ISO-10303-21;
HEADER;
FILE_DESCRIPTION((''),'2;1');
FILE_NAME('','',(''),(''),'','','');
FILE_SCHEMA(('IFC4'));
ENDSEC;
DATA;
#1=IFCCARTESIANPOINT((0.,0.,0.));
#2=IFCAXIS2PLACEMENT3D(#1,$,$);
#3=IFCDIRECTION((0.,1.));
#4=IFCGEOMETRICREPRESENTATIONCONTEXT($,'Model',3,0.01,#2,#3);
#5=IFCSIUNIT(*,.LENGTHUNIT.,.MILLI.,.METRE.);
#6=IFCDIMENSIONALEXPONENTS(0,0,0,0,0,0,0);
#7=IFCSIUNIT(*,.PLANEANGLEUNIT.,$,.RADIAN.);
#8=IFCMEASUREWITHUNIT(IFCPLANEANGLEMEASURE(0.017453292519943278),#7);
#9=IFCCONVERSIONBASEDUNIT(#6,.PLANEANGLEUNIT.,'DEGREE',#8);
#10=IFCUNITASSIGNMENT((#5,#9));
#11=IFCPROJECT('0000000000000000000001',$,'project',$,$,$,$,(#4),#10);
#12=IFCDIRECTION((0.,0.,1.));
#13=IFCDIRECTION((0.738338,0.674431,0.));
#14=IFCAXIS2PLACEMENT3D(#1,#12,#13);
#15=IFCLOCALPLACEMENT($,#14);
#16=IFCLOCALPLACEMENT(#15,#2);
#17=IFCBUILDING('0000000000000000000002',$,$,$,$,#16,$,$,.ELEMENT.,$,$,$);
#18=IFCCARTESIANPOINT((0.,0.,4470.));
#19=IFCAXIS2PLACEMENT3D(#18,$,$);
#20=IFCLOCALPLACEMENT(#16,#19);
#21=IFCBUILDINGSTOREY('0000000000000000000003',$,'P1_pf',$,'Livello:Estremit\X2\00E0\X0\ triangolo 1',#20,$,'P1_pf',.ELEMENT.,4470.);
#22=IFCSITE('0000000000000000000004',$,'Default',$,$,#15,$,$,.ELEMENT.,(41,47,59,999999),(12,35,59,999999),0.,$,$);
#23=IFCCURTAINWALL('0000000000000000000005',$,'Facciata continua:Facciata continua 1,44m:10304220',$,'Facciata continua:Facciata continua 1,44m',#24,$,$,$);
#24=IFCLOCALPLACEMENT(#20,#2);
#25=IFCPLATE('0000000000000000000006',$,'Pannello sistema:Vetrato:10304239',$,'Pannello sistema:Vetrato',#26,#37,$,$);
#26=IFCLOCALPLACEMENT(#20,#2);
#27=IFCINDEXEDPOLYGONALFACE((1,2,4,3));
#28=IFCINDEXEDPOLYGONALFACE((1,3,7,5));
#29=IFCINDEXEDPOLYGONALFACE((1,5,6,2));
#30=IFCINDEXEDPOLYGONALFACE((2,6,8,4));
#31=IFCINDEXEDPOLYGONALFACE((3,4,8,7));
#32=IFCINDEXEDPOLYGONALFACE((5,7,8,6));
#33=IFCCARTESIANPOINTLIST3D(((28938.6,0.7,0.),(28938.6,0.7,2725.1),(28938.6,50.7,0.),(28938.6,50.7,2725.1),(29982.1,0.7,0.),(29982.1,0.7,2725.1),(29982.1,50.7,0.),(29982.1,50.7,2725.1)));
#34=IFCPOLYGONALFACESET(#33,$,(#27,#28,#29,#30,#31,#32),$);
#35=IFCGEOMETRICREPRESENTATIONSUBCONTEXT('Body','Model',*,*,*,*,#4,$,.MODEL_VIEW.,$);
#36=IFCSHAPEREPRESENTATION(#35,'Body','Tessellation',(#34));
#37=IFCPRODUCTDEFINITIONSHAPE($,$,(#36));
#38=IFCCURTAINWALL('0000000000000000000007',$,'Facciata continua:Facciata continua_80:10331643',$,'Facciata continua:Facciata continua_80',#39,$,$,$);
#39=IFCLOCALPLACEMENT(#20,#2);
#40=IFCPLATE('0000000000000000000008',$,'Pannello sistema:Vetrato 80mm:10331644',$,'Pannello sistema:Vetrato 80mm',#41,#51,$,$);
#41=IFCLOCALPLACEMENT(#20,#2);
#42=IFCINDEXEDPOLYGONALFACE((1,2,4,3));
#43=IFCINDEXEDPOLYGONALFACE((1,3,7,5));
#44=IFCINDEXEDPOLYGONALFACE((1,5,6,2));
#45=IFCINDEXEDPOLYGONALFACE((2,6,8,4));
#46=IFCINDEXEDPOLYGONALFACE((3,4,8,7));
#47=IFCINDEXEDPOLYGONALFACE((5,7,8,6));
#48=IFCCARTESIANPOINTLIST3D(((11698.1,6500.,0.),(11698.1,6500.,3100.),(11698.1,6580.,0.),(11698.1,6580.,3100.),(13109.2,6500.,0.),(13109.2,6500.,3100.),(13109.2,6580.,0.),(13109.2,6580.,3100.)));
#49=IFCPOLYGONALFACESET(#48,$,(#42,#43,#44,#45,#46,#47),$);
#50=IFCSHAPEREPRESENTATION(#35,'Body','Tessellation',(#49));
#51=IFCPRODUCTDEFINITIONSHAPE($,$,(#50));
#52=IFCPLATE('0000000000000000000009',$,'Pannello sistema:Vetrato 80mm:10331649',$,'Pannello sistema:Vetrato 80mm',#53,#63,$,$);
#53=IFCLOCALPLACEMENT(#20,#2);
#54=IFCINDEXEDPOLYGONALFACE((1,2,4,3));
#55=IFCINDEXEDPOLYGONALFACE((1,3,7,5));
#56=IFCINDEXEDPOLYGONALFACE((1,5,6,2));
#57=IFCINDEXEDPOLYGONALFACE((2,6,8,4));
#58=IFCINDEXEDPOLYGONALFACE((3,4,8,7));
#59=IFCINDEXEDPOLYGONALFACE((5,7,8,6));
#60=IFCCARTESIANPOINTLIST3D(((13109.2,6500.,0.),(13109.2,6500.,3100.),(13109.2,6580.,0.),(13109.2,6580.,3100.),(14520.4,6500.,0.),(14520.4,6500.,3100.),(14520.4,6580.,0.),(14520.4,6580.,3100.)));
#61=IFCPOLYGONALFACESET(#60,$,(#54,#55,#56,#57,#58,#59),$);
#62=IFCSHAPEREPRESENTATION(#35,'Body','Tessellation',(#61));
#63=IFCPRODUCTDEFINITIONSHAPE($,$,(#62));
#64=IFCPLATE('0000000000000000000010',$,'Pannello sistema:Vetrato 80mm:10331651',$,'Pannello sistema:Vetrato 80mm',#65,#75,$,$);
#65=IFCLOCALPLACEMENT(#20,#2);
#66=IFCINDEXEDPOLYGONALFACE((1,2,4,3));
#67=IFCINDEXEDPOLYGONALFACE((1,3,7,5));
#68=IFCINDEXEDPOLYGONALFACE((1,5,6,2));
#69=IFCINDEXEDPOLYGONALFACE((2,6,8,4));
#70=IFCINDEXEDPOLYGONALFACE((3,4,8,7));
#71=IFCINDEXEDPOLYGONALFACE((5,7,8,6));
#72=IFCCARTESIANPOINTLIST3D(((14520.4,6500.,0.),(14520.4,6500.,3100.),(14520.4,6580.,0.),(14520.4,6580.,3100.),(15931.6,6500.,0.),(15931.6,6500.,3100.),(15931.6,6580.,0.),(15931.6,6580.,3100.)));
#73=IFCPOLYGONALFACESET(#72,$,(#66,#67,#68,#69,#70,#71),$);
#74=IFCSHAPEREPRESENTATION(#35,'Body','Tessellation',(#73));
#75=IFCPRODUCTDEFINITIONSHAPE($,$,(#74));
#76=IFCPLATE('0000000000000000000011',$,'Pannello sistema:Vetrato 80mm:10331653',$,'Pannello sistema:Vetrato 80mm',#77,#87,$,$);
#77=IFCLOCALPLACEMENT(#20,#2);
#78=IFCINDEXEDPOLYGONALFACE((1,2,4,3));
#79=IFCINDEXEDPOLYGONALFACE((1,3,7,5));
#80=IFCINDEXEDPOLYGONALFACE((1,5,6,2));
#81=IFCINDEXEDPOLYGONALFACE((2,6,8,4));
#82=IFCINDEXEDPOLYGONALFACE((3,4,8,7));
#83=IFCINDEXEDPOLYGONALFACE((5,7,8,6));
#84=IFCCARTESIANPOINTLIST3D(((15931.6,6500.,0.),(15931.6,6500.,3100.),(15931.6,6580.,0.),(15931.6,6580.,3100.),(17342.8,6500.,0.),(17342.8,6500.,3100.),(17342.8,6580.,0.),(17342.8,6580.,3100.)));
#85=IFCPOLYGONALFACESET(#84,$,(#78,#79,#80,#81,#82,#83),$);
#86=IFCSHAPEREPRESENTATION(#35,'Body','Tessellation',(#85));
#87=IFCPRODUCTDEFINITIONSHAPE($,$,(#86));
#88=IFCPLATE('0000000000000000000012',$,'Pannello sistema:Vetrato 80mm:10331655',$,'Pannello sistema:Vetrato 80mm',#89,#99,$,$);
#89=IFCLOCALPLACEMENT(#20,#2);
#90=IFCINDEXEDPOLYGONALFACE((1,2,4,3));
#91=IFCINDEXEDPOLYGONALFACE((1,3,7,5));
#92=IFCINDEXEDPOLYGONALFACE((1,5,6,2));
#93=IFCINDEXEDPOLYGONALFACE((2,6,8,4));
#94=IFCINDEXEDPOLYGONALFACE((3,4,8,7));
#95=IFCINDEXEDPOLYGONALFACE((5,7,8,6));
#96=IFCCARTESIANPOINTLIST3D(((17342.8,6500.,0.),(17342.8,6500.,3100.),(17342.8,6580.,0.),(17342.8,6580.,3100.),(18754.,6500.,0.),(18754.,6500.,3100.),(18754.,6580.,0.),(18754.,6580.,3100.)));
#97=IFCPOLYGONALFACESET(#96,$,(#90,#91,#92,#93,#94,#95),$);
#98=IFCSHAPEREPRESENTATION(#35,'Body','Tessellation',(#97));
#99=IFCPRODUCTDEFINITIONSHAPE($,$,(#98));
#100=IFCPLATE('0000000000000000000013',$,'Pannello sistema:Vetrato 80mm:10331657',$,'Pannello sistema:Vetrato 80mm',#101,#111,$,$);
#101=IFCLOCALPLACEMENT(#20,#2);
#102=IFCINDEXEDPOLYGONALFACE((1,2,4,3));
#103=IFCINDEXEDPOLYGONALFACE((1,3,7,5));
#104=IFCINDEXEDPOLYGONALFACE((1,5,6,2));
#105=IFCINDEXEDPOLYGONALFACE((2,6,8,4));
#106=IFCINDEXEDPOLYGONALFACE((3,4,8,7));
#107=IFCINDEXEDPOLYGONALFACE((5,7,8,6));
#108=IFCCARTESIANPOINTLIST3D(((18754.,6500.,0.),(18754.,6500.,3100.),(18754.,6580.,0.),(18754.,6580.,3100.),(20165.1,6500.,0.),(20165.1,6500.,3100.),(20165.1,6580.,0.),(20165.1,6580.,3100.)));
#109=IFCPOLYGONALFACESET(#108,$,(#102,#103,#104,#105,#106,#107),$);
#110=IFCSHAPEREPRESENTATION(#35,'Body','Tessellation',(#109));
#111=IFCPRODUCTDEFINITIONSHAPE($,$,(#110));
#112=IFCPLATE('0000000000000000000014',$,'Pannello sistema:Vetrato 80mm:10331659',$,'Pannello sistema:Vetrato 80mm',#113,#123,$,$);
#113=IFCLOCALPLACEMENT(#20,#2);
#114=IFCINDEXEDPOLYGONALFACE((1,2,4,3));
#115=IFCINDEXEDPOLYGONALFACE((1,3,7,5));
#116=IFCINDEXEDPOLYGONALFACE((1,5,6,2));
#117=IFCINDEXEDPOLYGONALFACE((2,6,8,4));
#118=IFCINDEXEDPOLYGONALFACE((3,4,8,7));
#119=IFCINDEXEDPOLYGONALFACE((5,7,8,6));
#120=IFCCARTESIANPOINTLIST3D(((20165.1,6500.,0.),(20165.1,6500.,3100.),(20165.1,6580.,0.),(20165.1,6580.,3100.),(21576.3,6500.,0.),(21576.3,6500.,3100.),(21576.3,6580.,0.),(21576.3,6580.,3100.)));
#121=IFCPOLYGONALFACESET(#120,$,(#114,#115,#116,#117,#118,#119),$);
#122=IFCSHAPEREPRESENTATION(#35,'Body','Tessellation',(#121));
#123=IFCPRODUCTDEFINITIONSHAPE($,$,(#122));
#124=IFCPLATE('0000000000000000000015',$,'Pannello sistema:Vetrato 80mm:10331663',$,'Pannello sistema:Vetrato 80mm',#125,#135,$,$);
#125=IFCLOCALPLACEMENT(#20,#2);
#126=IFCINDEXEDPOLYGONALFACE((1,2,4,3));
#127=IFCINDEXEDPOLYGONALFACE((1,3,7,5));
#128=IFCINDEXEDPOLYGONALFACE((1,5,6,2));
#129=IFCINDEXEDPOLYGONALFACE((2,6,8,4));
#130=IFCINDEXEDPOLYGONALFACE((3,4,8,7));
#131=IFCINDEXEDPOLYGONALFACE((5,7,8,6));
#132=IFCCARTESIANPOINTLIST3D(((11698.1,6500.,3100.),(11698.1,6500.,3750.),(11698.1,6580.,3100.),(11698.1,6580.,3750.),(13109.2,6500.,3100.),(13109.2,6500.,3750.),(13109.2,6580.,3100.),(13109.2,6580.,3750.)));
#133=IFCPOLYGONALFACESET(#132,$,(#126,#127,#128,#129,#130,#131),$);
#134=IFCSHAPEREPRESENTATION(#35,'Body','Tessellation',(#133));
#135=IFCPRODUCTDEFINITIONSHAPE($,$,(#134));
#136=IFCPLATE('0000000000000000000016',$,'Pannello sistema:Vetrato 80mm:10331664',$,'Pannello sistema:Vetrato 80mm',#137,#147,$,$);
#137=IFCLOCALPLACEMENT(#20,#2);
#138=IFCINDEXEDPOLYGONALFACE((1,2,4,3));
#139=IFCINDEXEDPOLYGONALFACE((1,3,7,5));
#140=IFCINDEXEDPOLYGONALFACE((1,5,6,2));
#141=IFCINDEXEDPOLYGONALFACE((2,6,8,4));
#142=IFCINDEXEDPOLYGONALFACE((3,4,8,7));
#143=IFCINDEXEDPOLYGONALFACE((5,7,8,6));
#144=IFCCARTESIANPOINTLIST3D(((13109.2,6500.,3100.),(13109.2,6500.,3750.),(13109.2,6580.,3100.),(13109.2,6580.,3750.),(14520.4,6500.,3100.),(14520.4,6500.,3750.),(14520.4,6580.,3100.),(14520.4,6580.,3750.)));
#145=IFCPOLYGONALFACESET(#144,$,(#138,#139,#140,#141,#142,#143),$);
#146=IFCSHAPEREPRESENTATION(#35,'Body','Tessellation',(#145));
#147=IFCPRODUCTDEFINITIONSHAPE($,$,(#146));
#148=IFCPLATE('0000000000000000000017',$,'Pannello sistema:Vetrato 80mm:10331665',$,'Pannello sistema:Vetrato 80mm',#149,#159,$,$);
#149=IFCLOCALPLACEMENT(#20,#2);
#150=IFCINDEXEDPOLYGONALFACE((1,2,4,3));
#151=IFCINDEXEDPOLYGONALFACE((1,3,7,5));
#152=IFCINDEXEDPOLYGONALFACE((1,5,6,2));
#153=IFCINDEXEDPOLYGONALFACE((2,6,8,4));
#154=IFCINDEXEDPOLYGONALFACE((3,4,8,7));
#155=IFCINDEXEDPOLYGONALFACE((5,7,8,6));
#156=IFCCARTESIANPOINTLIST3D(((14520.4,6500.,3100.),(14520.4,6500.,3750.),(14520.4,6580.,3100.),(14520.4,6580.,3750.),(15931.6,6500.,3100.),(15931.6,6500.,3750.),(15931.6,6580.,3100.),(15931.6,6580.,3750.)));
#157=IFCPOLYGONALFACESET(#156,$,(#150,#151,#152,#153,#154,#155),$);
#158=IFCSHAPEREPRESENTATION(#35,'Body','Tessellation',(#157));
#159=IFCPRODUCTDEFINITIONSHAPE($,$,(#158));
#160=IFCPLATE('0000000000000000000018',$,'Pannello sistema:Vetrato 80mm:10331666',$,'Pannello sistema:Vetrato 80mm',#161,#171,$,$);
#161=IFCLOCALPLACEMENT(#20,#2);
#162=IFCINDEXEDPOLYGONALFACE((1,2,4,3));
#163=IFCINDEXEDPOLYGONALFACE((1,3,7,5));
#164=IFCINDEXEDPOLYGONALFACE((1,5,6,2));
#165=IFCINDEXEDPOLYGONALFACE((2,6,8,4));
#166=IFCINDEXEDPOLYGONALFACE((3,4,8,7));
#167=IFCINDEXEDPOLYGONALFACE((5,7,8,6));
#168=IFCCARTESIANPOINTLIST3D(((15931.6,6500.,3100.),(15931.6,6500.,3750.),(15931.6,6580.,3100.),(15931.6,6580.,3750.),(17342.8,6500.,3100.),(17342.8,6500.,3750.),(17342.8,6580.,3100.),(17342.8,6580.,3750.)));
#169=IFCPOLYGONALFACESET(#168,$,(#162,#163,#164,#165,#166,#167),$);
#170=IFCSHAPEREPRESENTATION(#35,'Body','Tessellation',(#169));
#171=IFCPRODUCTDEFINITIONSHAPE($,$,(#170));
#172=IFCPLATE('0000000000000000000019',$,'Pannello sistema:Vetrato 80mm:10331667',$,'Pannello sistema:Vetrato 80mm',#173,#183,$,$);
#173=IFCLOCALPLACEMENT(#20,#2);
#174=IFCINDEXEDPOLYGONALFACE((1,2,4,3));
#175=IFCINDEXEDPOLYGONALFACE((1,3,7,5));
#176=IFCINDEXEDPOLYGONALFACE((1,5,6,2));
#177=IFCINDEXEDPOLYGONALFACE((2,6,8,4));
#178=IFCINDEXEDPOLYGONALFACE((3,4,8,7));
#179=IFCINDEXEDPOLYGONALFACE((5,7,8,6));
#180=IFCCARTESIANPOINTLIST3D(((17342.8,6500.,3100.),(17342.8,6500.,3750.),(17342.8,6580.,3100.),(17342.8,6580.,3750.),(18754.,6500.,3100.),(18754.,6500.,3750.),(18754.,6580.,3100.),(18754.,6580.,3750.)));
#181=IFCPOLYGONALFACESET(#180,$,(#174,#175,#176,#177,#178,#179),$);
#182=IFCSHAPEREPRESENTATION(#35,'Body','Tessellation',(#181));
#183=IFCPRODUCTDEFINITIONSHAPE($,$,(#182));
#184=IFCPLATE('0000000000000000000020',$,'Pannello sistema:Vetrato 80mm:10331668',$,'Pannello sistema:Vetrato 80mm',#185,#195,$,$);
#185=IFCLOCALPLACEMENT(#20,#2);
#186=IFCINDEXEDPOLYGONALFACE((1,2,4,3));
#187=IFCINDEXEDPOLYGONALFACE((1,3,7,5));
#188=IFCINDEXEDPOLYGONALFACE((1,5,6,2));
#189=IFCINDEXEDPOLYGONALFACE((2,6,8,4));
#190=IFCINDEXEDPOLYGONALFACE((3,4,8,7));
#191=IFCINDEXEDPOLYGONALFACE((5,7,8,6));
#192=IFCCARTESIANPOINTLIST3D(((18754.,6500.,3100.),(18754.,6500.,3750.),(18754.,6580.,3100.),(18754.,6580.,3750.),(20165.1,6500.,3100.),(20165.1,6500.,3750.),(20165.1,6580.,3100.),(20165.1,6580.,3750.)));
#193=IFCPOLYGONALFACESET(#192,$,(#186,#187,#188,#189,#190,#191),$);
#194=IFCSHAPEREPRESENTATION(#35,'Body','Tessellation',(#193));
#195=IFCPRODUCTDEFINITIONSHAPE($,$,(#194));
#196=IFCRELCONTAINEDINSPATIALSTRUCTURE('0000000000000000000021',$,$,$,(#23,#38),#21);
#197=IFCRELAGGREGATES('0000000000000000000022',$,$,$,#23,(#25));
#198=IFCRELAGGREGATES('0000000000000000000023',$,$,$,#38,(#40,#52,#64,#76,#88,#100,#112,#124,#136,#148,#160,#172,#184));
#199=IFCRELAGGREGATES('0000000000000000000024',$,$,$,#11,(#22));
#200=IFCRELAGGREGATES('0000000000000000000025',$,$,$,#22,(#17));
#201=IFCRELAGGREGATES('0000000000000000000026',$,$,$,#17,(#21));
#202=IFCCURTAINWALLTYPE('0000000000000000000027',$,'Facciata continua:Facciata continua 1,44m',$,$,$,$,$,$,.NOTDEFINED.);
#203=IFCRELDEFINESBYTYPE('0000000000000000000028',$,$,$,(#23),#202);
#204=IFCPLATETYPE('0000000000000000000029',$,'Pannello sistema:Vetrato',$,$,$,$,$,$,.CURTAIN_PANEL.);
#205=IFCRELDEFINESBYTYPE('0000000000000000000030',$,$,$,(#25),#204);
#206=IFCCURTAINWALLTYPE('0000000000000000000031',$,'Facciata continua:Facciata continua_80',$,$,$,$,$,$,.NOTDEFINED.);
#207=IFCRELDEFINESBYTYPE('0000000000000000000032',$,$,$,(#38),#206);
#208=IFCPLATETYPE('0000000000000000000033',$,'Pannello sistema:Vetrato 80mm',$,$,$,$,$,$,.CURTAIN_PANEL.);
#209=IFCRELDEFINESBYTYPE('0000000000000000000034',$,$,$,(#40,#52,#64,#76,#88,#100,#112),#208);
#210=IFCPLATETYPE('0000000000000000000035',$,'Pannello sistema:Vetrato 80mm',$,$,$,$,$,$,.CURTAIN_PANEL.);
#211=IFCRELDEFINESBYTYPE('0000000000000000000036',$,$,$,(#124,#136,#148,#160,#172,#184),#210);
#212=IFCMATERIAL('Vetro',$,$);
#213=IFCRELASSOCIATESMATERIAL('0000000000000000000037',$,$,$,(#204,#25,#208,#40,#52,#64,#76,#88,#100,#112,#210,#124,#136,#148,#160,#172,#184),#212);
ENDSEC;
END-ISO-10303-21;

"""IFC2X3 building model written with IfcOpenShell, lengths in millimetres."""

from ifc_helpers import new_model, entity, si_unit, converted_unit, direction, frame, origin, origin_2d_with_axis, place, context, subcontext, project, spatial, rectangle, extrude, source, transform, mapped, material, type_object, type_shapes, element, aggregate, save


model = new_model("IFC2X3")

# Units and contexts
model_context = context("Model", 3, precision=0.01, world=origin(), true_north=direction((0.0, 1.0)))
body_context = subcontext(model_context, "Body", "Model", "MODEL_VIEW")
ifc_project = project(units=[si_unit("LENGTHUNIT", "METRE", prefix="MILLI"), converted_unit("PLANEANGLEUNIT", "DEGREE", entity("IfcPlaneAngleMeasure", 0.017453292519943278), si_unit("PLANEANGLEUNIT", "RADIAN"), dimensions=[0, 0, 0, 0, 0, 0, 0])], contexts=[model_context])

# Site, building, storey
site_placement = place(None, frame((0.0, 0.0, 0.0), z_axis=(0.0, 0.0, 1.0), x_axis=(0.738338, 0.674431, 0.0)))
site = spatial("IfcSite", under=ifc_project, at=site_placement, Name="Default", CompositionType="ELEMENT", RefLatitude=(41, 47, 59, 999999), RefLongitude=(12, 35, 59, 999999), RefElevation=0.0)
building_placement = place(site_placement, origin())
building = spatial("IfcBuilding", under=site, at=building_placement, CompositionType="ELEMENT")
storey_placement = place(building_placement, frame((0.0, 0.0, 4470.0)))
storey = spatial("IfcBuildingStorey", under=building, at=storey_placement, Name="P1_pf", ObjectType="Livello:Estremità triangolo 1", LongName="P1_pf", CompositionType="ELEMENT", Elevation=4470.0)

# Curtain wall, plate
curtain_wall_type_1 = type_object("IfcCurtainWallType", Name="Facciata continua:Facciata continua 1,44m", PredefinedType="NOTDEFINED")
curtain_wall_1_placement = place(storey_placement, frame((0.0, 0.0, -4470.0)))
curtain_wall_1 = element("IfcCurtainWall", 1, at=curtain_wall_1_placement, inside=storey, type_object=curtain_wall_type_1, Name="Facciata continua:Facciata continua 1,44m:10304220", ObjectType="Facciata continua:Facciata continua 1,44m")
ifc_material_1 = material(Name="Vetro")
plate_type_1 = type_object("IfcPlateType", Name="Pannello sistema:Vetrato", PredefinedType="CURTAIN_PANEL", material=ifc_material_1)
shared_shape_1 = source(origin(), body_context, "Body", "SweptSolid", [
    extrude(rectangle(XDim=50.0, YDim=1043.5, at=origin_2d_with_axis()), frame((0.0, -25.0, 0.0), z_axis=(0.0, 0.0, 1.0), x_axis=(0.0, 1.0, 0.0)), (0.0, 0.0, 1.0), 2725.1),
])
type_shapes(plate_type_1, [shared_shape_1])
plate_1_placement = place(curtain_wall_1_placement, frame((29460.4, 0.7, 4470.0), z_axis=(0.0, 0.0, 1.0), x_axis=(-1.0, 0.0, 0.0)))
plate_1 = element("IfcPlate", 2, at=plate_1_placement, type_object=plate_type_1, material=ifc_material_1, Name="Pannello sistema:Vetrato:10304239", ObjectType="Pannello sistema:Vetrato", context=body_context, shape_type="MappedRepresentation", body=[
    mapped(shared_shape_1, transform((0.0, 0.0, 0.0), scale=1.0)),
])
aggregate(curtain_wall_1, [plate_1])

# Curtain wall, plates
curtain_wall_type_2 = type_object("IfcCurtainWallType", Name="Facciata continua:Facciata continua_80", PredefinedType="NOTDEFINED")
curtain_wall_2_placement = place(storey_placement, frame((0.0, 0.0, -4470.0)))
curtain_wall_2 = element("IfcCurtainWall", 3, at=curtain_wall_2_placement, inside=storey, type_object=curtain_wall_type_2, Name="Facciata continua:Facciata continua_80:10331643", ObjectType="Facciata continua:Facciata continua_80")
plate_type_2 = type_object("IfcPlateType", Name="Pannello sistema:Vetrato 80mm", PredefinedType="CURTAIN_PANEL", material=ifc_material_1)
shared_shape_2 = source(origin(), body_context, "Body", "SweptSolid", [
    extrude(rectangle(XDim=80.0, YDim=1411.2, at=origin_2d_with_axis()), frame((0.0, -40.0, 0.0), z_axis=(0.0, 0.0, 1.0), x_axis=(0.0, 1.0, 0.0)), (0.0, 0.0, 1.0), 3100.0),
])
type_shapes(plate_type_2, [shared_shape_2])
plate_2_placement = place(curtain_wall_2_placement, frame((12403.7, 6580.0, 4470.0)))
plate_2 = element("IfcPlate", 4, at=plate_2_placement, type_object=plate_type_2, material=ifc_material_1, Name="Pannello sistema:Vetrato 80mm:10331644", ObjectType="Pannello sistema:Vetrato 80mm", context=body_context, shape_type="MappedRepresentation", body=[
    mapped(shared_shape_2, transform((0.0, 0.0, 0.0), scale=1.0)),
])
plate_3_placement = place(curtain_wall_2_placement, frame((13814.8, 6580.0, 4470.0)))
plate_3 = element("IfcPlate", 5, at=plate_3_placement, type_object=plate_type_2, material=ifc_material_1, Name="Pannello sistema:Vetrato 80mm:10331649", ObjectType="Pannello sistema:Vetrato 80mm", context=body_context, shape_type="MappedRepresentation", body=[
    mapped(shared_shape_2, transform((0.0, 0.0, 0.0), scale=1.0)),
])
plate_4_placement = place(curtain_wall_2_placement, frame((15226.0, 6580.0, 4470.0)))
plate_4 = element("IfcPlate", 6, at=plate_4_placement, type_object=plate_type_2, material=ifc_material_1, Name="Pannello sistema:Vetrato 80mm:10331651", ObjectType="Pannello sistema:Vetrato 80mm", context=body_context, shape_type="MappedRepresentation", body=[
    mapped(shared_shape_2, transform((0.0, 0.0, 0.0), scale=1.0)),
])
plate_5_placement = place(curtain_wall_2_placement, frame((16637.2, 6580.0, 4470.0)))
plate_5 = element("IfcPlate", 7, at=plate_5_placement, type_object=plate_type_2, material=ifc_material_1, Name="Pannello sistema:Vetrato 80mm:10331653", ObjectType="Pannello sistema:Vetrato 80mm", context=body_context, shape_type="MappedRepresentation", body=[
    mapped(shared_shape_2, transform((0.0, 0.0, 0.0), scale=1.0)),
])
plate_6_placement = place(curtain_wall_2_placement, frame((18048.4, 6580.0, 4470.0)))
plate_6 = element("IfcPlate", 8, at=plate_6_placement, type_object=plate_type_2, material=ifc_material_1, Name="Pannello sistema:Vetrato 80mm:10331655", ObjectType="Pannello sistema:Vetrato 80mm", context=body_context, shape_type="MappedRepresentation", body=[
    mapped(shared_shape_2, transform((0.0, 0.0, 0.0), scale=1.0)),
])
plate_7_placement = place(curtain_wall_2_placement, frame((19459.5, 6580.0, 4470.0)))
plate_7 = element("IfcPlate", 9, at=plate_7_placement, type_object=plate_type_2, material=ifc_material_1, Name="Pannello sistema:Vetrato 80mm:10331657", ObjectType="Pannello sistema:Vetrato 80mm", context=body_context, shape_type="MappedRepresentation", body=[
    mapped(shared_shape_2, transform((0.0, 0.0, 0.0), scale=1.0)),
])
plate_8_placement = place(curtain_wall_2_placement, frame((20870.7, 6580.0, 4470.0)))
plate_8 = element("IfcPlate", 10, at=plate_8_placement, type_object=plate_type_2, material=ifc_material_1, Name="Pannello sistema:Vetrato 80mm:10331659", ObjectType="Pannello sistema:Vetrato 80mm", context=body_context, shape_type="MappedRepresentation", body=[
    mapped(shared_shape_2, transform((0.0, 0.0, 0.0), scale=1.0)),
])
plate_type_3 = type_object("IfcPlateType", Name="Pannello sistema:Vetrato 80mm", PredefinedType="CURTAIN_PANEL", material=ifc_material_1)
shared_shape_3 = source(origin(), body_context, "Body", "SweptSolid", [
    extrude(rectangle(XDim=80.0, YDim=1411.2, at=origin_2d_with_axis()), frame((0.0, -40.0, 0.0), z_axis=(0.0, 0.0, 1.0), x_axis=(0.0, 1.0, 0.0)), (0.0, 0.0, 1.0), 650.0),
])
type_shapes(plate_type_3, [shared_shape_3])
plate_9_placement = place(curtain_wall_2_placement, frame((12403.7, 6580.0, 7570.0)))
plate_9 = element("IfcPlate", 11, at=plate_9_placement, type_object=plate_type_3, material=ifc_material_1, Name="Pannello sistema:Vetrato 80mm:10331663", ObjectType="Pannello sistema:Vetrato 80mm", context=body_context, shape_type="MappedRepresentation", body=[
    mapped(shared_shape_3, transform((0.0, 0.0, 0.0), scale=1.0)),
])
plate_10_placement = place(curtain_wall_2_placement, frame((13814.8, 6580.0, 7570.0)))
plate_10 = element("IfcPlate", 12, at=plate_10_placement, type_object=plate_type_3, material=ifc_material_1, Name="Pannello sistema:Vetrato 80mm:10331664", ObjectType="Pannello sistema:Vetrato 80mm", context=body_context, shape_type="MappedRepresentation", body=[
    mapped(shared_shape_3, transform((0.0, 0.0, 0.0), scale=1.0)),
])
plate_11_placement = place(curtain_wall_2_placement, frame((15226.0, 6580.0, 7570.0)))
plate_11 = element("IfcPlate", 13, at=plate_11_placement, type_object=plate_type_3, material=ifc_material_1, Name="Pannello sistema:Vetrato 80mm:10331665", ObjectType="Pannello sistema:Vetrato 80mm", context=body_context, shape_type="MappedRepresentation", body=[
    mapped(shared_shape_3, transform((0.0, 0.0, 0.0), scale=1.0)),
])
plate_12_placement = place(curtain_wall_2_placement, frame((16637.2, 6580.0, 7570.0)))
plate_12 = element("IfcPlate", 14, at=plate_12_placement, type_object=plate_type_3, material=ifc_material_1, Name="Pannello sistema:Vetrato 80mm:10331666", ObjectType="Pannello sistema:Vetrato 80mm", context=body_context, shape_type="MappedRepresentation", body=[
    mapped(shared_shape_3, transform((0.0, 0.0, 0.0), scale=1.0)),
])
plate_13_placement = place(curtain_wall_2_placement, frame((18048.4, 6580.0, 7570.0)))
plate_13 = element("IfcPlate", 15, at=plate_13_placement, type_object=plate_type_3, material=ifc_material_1, Name="Pannello sistema:Vetrato 80mm:10331667", ObjectType="Pannello sistema:Vetrato 80mm", context=body_context, shape_type="MappedRepresentation", body=[
    mapped(shared_shape_3, transform((0.0, 0.0, 0.0), scale=1.0)),
])
plate_14_placement = place(curtain_wall_2_placement, frame((19459.5, 6580.0, 7570.0)))
plate_14 = element("IfcPlate", 16, at=plate_14_placement, type_object=plate_type_3, material=ifc_material_1, Name="Pannello sistema:Vetrato 80mm:10331668", ObjectType="Pannello sistema:Vetrato 80mm", context=body_context, shape_type="MappedRepresentation", body=[
    mapped(shared_shape_3, transform((0.0, 0.0, 0.0), scale=1.0)),
])
aggregate(curtain_wall_2, [plate_2, plate_3, plate_4, plate_5, plate_6, plate_7, plate_8, plate_9, plate_10, plate_11, plate_12, plate_13, plate_14])

save(model, "model.ifc")
